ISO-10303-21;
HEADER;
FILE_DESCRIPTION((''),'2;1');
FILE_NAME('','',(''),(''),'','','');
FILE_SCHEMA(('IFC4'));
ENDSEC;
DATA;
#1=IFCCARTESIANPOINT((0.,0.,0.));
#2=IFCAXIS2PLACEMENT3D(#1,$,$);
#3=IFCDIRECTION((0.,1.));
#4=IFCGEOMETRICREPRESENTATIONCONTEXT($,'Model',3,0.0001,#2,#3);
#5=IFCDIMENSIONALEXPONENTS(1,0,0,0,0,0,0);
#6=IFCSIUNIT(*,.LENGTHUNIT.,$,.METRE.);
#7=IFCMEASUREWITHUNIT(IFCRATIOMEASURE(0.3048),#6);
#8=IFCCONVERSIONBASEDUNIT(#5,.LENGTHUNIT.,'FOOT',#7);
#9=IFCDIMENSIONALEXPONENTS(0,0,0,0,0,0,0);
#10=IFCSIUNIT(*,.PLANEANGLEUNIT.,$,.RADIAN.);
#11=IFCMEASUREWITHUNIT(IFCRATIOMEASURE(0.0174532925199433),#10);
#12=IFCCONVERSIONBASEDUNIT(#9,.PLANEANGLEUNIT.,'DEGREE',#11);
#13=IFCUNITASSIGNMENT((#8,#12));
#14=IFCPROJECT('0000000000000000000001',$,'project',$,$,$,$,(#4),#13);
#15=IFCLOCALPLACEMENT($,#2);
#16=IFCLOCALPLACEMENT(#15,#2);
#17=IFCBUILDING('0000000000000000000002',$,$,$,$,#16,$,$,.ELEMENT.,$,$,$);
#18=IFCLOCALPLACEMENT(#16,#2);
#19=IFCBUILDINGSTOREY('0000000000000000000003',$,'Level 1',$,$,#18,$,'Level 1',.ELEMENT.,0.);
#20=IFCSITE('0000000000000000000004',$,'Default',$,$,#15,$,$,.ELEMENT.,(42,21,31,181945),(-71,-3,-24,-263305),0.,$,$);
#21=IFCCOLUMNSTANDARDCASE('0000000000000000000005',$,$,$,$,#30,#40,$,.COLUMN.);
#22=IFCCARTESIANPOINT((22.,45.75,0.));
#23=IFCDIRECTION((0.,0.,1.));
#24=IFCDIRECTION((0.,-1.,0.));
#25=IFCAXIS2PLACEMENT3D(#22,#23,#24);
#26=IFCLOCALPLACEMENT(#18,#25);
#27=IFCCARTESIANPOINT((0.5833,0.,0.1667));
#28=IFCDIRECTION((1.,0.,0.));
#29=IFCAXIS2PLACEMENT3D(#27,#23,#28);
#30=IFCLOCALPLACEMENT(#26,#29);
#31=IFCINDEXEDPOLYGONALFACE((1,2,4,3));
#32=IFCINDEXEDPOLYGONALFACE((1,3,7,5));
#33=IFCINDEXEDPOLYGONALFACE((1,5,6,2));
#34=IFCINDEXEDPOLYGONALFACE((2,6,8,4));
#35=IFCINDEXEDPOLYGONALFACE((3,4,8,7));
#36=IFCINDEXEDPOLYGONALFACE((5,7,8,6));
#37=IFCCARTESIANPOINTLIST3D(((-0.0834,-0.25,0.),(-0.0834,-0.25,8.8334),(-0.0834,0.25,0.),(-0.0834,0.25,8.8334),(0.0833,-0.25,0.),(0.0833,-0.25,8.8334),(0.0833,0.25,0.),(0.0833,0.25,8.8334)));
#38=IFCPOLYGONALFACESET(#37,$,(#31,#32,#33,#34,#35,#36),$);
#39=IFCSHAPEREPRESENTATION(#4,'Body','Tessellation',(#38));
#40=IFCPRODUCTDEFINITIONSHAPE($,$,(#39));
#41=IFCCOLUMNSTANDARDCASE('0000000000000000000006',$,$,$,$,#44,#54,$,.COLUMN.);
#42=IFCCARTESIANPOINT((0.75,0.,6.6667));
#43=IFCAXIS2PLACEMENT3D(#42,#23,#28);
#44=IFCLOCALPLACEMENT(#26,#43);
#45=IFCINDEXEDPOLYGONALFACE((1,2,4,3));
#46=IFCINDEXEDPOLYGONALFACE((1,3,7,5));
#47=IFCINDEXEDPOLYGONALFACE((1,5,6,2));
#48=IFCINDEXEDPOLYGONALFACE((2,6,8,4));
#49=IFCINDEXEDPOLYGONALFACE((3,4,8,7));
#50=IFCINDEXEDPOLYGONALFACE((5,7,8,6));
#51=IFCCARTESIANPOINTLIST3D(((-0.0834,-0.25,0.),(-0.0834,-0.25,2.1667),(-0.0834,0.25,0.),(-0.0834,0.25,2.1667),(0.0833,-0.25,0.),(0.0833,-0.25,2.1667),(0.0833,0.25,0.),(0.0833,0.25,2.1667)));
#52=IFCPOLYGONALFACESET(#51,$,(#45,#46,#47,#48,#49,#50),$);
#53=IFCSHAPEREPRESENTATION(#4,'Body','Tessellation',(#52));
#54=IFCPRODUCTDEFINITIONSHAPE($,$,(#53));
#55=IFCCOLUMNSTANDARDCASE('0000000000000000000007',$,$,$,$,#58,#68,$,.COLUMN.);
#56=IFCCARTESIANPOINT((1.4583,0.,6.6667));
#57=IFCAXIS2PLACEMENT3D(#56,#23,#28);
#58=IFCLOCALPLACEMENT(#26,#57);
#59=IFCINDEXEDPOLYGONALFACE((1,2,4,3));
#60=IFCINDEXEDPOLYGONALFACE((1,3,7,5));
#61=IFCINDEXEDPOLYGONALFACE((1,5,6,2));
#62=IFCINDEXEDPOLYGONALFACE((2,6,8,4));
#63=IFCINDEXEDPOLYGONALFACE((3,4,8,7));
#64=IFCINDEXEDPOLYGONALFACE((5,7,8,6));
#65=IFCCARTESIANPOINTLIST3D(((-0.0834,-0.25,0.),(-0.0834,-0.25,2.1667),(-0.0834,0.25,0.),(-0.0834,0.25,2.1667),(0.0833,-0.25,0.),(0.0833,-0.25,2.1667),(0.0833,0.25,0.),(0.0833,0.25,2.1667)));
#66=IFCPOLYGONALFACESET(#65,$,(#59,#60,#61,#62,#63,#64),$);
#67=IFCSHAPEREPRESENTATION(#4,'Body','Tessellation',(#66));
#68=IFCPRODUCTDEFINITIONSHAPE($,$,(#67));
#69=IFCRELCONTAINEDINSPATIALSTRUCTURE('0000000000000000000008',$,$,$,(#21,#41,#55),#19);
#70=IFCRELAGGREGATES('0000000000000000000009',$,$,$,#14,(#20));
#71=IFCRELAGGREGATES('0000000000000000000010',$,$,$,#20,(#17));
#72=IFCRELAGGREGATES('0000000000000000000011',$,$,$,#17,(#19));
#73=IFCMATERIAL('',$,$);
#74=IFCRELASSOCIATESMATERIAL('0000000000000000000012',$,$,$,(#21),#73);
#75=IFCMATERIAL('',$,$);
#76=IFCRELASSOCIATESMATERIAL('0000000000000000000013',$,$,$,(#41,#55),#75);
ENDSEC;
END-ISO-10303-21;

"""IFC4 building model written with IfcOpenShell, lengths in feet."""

from ifc_helpers import new_model, entity, si_unit, converted_unit, direction, frame, origin, place, context, project, spatial, rectangle, extrude, material, element, save


model = new_model("IFC4")

# Units and contexts
model_context = context("Model", 3, precision=0.0001, world=origin(), true_north=direction((0.0, 1.0)))
ifc_project = project(units=[converted_unit("LENGTHUNIT", "FOOT", entity("IfcRatioMeasure", 0.3048), si_unit("LENGTHUNIT", "METRE"), dimensions=[1, 0, 0, 0, 0, 0, 0]), converted_unit("PLANEANGLEUNIT", "DEGREE", entity("IfcRatioMeasure", 0.0174532925199433), si_unit("PLANEANGLEUNIT", "RADIAN"), dimensions=[0, 0, 0, 0, 0, 0, 0])], contexts=[model_context])

# Site, building, storey
site_placement = place(None, origin())
site = spatial("IfcSite", under=ifc_project, at=site_placement, Name="Default", CompositionType="ELEMENT", RefLatitude=(42, 21, 31, 181945), RefLongitude=(-71, -3, -24, -263305), RefElevation=0.0)
building_placement = place(site_placement, origin())
building = spatial("IfcBuilding", under=site, at=building_placement, CompositionType="ELEMENT")
storey_placement = place(building_placement, origin())
storey = spatial("IfcBuildingStorey", under=building, at=storey_placement, Name="Level 1", LongName="Level 1", CompositionType="ELEMENT", Elevation=0.0)

# Columns
ifc_material_1 = material(Name="")
ifc_material_2 = material(Name="")
placement_1 = place(storey_placement, frame((22.0, 45.75, 0.0), z_axis=(0.0, 0.0, 1.0), x_axis=(0.0, -1.0, 0.0)))
for number, where, z_axis, x_axis in (
    (1, (0.5833, 0.0, 0.1667), (0.0, 0.0, 1.0), (1.0, 0.0, 0.0)),
):
    element("IfcColumnStandardCase", number, at=place(placement_1, frame(where, z_axis=z_axis, x_axis=x_axis)), inside=storey, material=ifc_material_2, PredefinedType="COLUMN", context=model_context, shape_type="SweptSolid", body=[
        extrude(rectangle(XDim=0.1667, YDim=0.5), origin(), (0.0, 0.0, 1.0), 8.8334),
    ])
for number, where, z_axis, x_axis in (
    (2, (0.75, 0.0, 6.6667), (0.0, 0.0, 1.0), (1.0, 0.0, 0.0)),
    (3, (1.4583, 0.0, 6.6667), (0.0, 0.0, 1.0), (1.0, 0.0, 0.0)),
):
    element("IfcColumnStandardCase", number, at=place(placement_1, frame(where, z_axis=z_axis, x_axis=x_axis)), inside=storey, material=ifc_material_1, PredefinedType="COLUMN", context=model_context, shape_type="SweptSolid", body=[
        extrude(rectangle(XDim=0.1667, YDim=0.5), origin(), (0.0, 0.0, 1.0), 2.1667),
    ])

save(model, "model.ifc")
